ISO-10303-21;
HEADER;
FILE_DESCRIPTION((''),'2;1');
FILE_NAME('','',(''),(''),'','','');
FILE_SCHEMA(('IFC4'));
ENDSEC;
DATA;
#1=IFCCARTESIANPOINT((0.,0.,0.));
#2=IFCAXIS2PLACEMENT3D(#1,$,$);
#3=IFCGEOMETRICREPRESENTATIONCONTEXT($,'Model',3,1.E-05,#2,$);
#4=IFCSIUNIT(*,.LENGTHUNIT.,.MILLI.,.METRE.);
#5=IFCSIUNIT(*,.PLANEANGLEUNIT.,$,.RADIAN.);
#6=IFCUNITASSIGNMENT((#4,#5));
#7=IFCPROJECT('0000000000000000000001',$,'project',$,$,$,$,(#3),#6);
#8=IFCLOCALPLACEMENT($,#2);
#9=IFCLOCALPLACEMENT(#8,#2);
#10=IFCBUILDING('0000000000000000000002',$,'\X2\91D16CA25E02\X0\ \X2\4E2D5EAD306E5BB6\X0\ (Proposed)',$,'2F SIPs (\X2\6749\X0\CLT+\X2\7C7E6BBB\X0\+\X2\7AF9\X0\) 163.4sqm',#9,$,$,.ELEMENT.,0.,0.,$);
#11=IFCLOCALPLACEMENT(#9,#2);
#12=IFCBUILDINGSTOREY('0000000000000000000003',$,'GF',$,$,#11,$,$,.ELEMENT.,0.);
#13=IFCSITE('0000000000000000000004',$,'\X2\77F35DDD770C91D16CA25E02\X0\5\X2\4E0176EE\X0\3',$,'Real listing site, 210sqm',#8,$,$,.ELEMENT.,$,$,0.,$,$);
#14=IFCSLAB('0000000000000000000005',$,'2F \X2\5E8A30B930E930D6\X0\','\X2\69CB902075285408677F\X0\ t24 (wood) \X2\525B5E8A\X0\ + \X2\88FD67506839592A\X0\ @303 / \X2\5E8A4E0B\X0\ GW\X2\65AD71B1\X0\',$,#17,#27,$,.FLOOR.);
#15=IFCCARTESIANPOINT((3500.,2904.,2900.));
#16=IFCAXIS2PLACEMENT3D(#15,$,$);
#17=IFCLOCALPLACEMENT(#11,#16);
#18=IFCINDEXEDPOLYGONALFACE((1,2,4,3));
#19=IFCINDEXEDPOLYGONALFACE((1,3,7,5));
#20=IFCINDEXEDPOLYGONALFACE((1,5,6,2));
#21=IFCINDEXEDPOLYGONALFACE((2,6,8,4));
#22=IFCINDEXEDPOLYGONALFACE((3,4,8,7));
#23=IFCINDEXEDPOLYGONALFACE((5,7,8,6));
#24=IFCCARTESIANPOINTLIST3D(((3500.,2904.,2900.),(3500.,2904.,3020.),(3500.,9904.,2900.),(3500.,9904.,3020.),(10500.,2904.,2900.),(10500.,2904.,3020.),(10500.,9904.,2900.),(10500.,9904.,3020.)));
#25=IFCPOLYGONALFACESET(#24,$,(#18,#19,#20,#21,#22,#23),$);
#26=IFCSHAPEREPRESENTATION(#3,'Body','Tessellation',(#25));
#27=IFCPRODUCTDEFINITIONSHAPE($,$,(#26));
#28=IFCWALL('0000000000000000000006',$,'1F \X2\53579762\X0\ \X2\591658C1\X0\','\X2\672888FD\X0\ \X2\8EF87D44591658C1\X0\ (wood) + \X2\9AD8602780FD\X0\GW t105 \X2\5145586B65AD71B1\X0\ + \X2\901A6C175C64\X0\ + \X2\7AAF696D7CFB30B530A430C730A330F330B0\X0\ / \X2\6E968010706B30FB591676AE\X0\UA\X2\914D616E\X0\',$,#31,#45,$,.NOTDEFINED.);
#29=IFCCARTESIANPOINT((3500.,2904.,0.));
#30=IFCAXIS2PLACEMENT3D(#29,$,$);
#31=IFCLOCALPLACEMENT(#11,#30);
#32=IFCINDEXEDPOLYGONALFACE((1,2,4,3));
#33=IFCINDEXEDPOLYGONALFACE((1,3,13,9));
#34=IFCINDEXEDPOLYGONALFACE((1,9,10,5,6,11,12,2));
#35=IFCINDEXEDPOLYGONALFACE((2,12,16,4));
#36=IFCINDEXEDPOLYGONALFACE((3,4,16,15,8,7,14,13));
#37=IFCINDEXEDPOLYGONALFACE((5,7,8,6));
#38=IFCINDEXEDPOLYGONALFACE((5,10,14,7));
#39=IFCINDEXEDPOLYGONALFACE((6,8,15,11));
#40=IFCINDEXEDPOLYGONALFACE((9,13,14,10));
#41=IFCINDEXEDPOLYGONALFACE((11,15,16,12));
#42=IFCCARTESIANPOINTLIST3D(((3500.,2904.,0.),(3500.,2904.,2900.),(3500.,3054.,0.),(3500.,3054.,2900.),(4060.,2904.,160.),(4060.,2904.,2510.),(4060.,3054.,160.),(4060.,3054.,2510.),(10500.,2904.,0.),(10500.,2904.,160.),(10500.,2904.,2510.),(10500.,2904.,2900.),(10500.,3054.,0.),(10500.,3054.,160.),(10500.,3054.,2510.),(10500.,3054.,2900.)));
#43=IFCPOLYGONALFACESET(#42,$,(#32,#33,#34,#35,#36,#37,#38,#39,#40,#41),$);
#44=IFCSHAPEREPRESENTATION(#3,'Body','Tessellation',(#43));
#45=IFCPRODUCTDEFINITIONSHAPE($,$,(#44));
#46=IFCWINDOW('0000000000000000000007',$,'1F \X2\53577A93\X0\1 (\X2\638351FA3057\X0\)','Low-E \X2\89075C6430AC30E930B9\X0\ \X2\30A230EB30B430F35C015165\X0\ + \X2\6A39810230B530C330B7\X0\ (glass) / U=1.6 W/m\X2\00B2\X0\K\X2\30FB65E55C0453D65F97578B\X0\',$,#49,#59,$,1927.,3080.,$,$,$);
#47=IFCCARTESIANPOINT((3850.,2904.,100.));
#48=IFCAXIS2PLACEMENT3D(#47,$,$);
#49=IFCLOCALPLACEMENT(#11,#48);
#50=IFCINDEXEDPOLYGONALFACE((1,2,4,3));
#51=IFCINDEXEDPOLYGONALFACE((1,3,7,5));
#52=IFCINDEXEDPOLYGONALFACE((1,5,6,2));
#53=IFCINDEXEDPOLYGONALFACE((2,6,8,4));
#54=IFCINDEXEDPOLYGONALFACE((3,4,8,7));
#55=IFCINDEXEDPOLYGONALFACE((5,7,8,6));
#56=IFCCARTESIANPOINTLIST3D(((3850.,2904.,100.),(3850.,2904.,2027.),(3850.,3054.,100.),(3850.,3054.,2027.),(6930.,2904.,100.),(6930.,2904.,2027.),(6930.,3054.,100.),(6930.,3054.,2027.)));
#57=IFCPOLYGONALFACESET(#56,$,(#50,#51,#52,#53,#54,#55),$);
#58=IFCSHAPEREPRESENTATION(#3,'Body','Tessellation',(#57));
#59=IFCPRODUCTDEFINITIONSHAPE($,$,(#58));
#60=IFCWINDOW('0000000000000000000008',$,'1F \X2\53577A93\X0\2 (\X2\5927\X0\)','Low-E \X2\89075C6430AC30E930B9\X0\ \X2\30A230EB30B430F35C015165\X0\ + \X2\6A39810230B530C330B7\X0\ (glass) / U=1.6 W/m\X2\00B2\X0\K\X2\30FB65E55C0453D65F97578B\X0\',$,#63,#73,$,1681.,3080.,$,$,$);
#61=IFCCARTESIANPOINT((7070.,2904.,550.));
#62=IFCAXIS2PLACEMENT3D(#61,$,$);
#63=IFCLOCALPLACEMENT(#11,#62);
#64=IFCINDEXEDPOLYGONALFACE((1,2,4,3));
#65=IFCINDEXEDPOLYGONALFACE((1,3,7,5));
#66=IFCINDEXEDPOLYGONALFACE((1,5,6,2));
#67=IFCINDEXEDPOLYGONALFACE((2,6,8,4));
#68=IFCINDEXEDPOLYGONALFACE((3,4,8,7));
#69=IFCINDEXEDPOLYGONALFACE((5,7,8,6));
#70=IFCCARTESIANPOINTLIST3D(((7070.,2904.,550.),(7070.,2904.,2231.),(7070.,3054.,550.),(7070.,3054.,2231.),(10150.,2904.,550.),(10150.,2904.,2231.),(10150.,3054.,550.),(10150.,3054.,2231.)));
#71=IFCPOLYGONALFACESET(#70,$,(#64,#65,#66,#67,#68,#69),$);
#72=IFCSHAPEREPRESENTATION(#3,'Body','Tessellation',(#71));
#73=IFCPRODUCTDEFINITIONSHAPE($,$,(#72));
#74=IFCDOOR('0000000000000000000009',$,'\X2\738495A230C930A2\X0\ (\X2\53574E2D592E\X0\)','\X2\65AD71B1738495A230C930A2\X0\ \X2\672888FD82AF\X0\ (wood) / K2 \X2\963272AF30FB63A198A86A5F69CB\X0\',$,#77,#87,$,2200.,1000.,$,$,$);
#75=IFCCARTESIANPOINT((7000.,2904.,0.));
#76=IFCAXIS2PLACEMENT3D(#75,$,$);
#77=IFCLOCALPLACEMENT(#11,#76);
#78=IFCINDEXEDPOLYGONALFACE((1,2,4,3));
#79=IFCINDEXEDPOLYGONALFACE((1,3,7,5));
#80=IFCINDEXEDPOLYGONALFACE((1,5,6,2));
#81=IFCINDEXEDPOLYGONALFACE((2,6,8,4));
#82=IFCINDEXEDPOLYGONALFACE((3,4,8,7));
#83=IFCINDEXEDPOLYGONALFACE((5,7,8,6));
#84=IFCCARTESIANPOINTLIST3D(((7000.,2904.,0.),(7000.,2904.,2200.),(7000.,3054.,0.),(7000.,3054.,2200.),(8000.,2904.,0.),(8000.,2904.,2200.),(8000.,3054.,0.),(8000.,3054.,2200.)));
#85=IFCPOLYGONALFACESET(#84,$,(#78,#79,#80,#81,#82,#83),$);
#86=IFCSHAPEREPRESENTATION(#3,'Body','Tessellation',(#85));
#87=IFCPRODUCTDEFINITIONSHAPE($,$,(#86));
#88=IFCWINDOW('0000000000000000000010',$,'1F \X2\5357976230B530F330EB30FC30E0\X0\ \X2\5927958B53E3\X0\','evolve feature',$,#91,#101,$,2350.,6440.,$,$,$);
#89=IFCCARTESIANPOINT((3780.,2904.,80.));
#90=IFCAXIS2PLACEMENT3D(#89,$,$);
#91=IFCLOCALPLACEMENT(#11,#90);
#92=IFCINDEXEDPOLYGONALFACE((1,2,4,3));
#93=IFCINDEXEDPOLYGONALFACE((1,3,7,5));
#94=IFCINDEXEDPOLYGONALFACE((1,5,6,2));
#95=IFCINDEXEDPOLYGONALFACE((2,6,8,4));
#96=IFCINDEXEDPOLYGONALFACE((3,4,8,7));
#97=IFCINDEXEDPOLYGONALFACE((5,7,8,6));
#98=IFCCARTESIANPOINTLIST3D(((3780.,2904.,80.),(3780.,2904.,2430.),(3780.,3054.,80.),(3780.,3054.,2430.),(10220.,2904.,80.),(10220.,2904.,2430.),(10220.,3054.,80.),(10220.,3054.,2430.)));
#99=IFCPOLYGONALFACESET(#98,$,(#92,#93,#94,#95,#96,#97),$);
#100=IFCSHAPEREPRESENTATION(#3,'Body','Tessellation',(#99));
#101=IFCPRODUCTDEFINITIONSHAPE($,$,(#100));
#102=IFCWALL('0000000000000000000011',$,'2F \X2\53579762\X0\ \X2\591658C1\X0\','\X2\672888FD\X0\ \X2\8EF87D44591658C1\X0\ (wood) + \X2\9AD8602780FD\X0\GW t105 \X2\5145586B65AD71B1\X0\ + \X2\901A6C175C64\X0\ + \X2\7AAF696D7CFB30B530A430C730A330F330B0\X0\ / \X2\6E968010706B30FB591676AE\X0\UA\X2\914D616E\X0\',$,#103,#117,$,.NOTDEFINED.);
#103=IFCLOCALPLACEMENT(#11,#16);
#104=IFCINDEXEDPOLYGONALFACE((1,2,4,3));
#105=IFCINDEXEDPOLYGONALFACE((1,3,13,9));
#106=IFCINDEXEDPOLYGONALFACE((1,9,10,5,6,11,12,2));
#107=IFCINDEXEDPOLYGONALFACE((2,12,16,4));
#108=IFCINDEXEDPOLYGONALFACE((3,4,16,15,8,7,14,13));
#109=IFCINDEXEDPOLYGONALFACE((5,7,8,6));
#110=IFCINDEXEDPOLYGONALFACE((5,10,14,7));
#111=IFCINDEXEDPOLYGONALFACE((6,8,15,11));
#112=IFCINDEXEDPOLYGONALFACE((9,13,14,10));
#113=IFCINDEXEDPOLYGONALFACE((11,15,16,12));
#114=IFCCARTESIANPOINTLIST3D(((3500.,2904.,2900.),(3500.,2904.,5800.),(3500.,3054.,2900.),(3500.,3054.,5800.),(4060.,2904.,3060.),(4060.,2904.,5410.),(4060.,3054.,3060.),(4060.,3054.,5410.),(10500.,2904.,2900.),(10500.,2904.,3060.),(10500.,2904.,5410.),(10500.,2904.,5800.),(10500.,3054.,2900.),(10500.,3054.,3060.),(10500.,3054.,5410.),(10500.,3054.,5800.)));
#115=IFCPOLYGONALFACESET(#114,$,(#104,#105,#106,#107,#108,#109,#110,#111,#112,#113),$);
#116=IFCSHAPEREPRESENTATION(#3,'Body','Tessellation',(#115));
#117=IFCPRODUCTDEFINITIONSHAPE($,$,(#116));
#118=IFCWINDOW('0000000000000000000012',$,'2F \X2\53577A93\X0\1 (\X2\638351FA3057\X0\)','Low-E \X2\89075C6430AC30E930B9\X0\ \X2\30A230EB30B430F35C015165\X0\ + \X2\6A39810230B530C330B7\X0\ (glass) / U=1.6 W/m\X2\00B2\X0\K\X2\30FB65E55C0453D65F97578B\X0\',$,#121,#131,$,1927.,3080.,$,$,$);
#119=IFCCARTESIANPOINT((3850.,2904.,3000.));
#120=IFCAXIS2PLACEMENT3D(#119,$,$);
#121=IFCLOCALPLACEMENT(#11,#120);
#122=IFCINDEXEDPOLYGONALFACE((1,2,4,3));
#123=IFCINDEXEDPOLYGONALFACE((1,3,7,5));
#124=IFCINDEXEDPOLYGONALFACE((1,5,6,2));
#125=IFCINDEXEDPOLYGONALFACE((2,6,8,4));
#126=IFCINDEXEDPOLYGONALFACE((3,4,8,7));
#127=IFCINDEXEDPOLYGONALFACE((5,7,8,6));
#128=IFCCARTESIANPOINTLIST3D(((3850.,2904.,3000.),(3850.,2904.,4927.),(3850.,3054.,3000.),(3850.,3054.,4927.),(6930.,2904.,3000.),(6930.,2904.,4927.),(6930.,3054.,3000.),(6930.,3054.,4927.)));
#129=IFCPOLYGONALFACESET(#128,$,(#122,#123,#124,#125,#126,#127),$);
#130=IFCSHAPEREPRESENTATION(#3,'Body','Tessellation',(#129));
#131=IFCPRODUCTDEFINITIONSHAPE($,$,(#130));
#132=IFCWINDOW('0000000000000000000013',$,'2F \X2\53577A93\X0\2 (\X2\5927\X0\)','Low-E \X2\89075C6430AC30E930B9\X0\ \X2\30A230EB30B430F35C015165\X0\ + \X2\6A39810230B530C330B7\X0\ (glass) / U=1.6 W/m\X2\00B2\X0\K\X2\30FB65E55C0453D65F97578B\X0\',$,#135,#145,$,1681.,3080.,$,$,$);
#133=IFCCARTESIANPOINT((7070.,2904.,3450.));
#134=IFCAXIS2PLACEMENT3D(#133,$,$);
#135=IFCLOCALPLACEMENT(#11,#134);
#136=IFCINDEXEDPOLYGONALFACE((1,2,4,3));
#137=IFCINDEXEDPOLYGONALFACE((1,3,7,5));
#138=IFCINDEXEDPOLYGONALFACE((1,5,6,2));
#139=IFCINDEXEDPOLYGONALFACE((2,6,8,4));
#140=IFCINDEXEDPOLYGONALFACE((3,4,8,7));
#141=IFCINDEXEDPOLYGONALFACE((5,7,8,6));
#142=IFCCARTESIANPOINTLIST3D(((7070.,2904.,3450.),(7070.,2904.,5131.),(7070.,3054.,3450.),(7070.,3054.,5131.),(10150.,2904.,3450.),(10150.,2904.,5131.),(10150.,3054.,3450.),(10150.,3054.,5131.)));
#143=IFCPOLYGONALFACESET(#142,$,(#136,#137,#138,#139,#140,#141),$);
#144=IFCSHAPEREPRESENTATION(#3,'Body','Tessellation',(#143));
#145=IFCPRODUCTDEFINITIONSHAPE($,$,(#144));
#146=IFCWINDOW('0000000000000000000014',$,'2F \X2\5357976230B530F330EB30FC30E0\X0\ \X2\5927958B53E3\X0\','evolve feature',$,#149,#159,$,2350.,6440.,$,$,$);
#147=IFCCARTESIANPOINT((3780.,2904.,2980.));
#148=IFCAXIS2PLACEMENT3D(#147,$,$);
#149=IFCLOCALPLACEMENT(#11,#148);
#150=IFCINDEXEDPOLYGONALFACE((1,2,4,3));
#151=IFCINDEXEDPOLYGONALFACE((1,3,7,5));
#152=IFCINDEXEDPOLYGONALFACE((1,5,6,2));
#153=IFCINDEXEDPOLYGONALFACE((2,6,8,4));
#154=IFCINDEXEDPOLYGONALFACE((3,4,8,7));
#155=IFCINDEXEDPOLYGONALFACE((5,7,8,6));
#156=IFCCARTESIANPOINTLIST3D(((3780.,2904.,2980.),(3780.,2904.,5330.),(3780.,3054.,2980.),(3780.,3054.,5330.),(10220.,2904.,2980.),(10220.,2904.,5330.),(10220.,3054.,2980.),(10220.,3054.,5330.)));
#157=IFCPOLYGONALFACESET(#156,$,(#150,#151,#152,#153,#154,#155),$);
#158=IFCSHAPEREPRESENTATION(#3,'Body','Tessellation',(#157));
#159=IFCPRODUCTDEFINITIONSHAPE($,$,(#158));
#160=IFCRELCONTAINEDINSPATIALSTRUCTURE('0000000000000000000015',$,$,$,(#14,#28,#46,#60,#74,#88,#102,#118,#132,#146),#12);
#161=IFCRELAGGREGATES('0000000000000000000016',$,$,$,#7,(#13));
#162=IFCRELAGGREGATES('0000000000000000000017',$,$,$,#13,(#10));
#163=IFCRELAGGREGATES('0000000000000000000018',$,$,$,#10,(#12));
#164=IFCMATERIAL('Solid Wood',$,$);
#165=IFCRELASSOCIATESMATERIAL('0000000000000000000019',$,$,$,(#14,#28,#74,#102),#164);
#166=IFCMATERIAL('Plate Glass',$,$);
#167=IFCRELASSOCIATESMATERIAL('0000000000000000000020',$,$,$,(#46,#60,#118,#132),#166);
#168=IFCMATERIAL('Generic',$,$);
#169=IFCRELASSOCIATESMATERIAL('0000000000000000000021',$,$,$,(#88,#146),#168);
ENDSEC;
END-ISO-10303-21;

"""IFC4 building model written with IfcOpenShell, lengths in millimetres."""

from ifc_helpers import new_model, si_unit, frame, frame_2d, origin, place, context, project, spatial, rectangle, extrude, material, element, fill, save


model = new_model("IFC4")

# Units and contexts
model_context = context("Model", 3, precision=1e-05, world=origin())
ifc_project = project(units=[si_unit("LENGTHUNIT", "METRE", prefix="MILLI"), si_unit("PLANEANGLEUNIT", "RADIAN")], contexts=[model_context])

# Site, building, storey
site_placement = place(None, origin())
site = spatial("IfcSite", under=ifc_project, at=site_placement, Name="石川県金沢市5丁目3", ObjectType="Real listing site, 210sqm", CompositionType="ELEMENT", RefElevation=0.0)
building_placement = place(site_placement, origin())
building = spatial("IfcBuilding", under=site, at=building_placement, Name="金沢市 中庭の家 (Proposed)", ObjectType="2F SIPs (杉CLT+籾殻+竹) 163.4sqm", CompositionType="ELEMENT", ElevationOfRefHeight=0.0, ElevationOfTerrain=0.0)
storey_placement = place(building_placement, origin())
storey = spatial("IfcBuildingStorey", under=building, at=storey_placement, Name="GF", CompositionType="ELEMENT", Elevation=0.0)

# Slab
ifc_material_1 = material(Name="Solid Wood")
slab_1_placement = place(storey_placement, frame((3500.0, 2904.0, 2900.0)))
element("IfcSlab", 1, at=slab_1_placement, inside=storey, material=ifc_material_1, Name="2F 床スラブ", Description="構造用合板 t24 (wood) 剛床 + 製材根太 @303 / 床下 GW断熱", PredefinedType="FLOOR", context=model_context, shape_type="SweptSolid", body=[
    extrude(rectangle(XDim=7000.0, YDim=7000.0, at=frame_2d((3500.0, 3500.0))), frame((3500.0, 2904.0, 2900.0)), (0.0, 0.0, 1.0), 120.0),
])
ifc_material_2 = material(Name="Generic")

# Wall, openings, windows, door
wall_1_placement = place(storey_placement, frame((3500.0, 2904.0, 0.0)))
wall_1 = element("IfcWall", 2, at=wall_1_placement, inside=storey, material=ifc_material_1, Name="1F 南面 外壁", Description="木製 軸組外壁 (wood) + 高性能GW t105 充填断熱 + 通気層 + 窯業系サイディング / 準耐火・外皮UA配慮", PredefinedType="NOTDEFINED", context=model_context, shape_type="SweptSolid", body=[
    extrude(rectangle(XDim=7000.0, YDim=150.0, at=frame_2d((3500.0, 75.0))), frame((3500.0, 2904.0, 0.0)), (0.0, 0.0, 1.0), 2900.0),
])
opening_1_placement = place(storey_placement, frame((3850.0, 2904.0, 100.0)))
opening_1 = element("IfcOpeningElement", 3, at=opening_1_placement, cuts=wall_1, PredefinedType="NOTDEFINED", context=model_context, shape_type="SweptSolid", body=[
    extrude(rectangle(XDim=3080.0, YDim=150.0, at=frame_2d((1540.0, 75.0))), frame((3850.0, 2904.0, 100.0)), (0.0, 0.0, 1.0), 1927.0),
])
opening_2_placement = place(storey_placement, frame((7070.0, 2904.0, 550.0)))
opening_2 = element("IfcOpeningElement", 4, at=opening_2_placement, cuts=wall_1, PredefinedType="NOTDEFINED", context=model_context, shape_type="SweptSolid", body=[
    extrude(rectangle(XDim=3080.0, YDim=150.0, at=frame_2d((1540.0, 75.0))), frame((7070.0, 2904.0, 550.0)), (0.0, 0.0, 1.0), 1681.0),
])
opening_3_placement = place(storey_placement, frame((7000.0, 2904.0, 0.0)))
opening_3 = element("IfcOpeningElement", 5, at=opening_3_placement, cuts=wall_1, PredefinedType="NOTDEFINED", context=model_context, shape_type="SweptSolid", body=[
    extrude(rectangle(XDim=1000.0, YDim=150.0, at=frame_2d((500.0, 75.0))), frame((7000.0, 2904.0, 0.0)), (0.0, 0.0, 1.0), 2200.0),
])
opening_4_placement = place(storey_placement, frame((3780.0, 2904.0, 80.0)))
opening_4 = element("IfcOpeningElement", 6, at=opening_4_placement, cuts=wall_1, PredefinedType="NOTDEFINED", context=model_context, shape_type="SweptSolid", body=[
    extrude(rectangle(XDim=6440.0, YDim=150.0, at=frame_2d((3220.0, 75.0))), frame((3780.0, 2904.0, 80.0)), (0.0, 0.0, 1.0), 2350.0),
])
ifc_material_3 = material(Name="Plate Glass")
window_1_placement = place(storey_placement, frame((3850.0, 2904.0, 100.0)))
window_1 = element("IfcWindow", 7, at=window_1_placement, inside=storey, material=ifc_material_3, Name="1F 南窓1 (掃出し)", Description="Low-E 複層ガラス アルゴン封入 + 樹脂サッシ (glass) / U=1.6 W/m²K・日射取得型", OverallHeight=1927.0, OverallWidth=3080.0, context=model_context, shape_type="SweptSolid", body=[
    extrude(rectangle(XDim=3080.0, YDim=150.0, at=frame_2d((1540.0, 75.0))), frame((3850.0, 2904.0, 100.0)), (0.0, 0.0, 1.0), 1927.0),
])
fill(opening_1, window_1)
window_2_placement = place(storey_placement, frame((7070.0, 2904.0, 550.0)))
window_2 = element("IfcWindow", 8, at=window_2_placement, inside=storey, material=ifc_material_3, Name="1F 南窓2 (大)", Description="Low-E 複層ガラス アルゴン封入 + 樹脂サッシ (glass) / U=1.6 W/m²K・日射取得型", OverallHeight=1681.0, OverallWidth=3080.0, context=model_context, shape_type="SweptSolid", body=[
    extrude(rectangle(XDim=3080.0, YDim=150.0, at=frame_2d((1540.0, 75.0))), frame((7070.0, 2904.0, 550.0)), (0.0, 0.0, 1.0), 1681.0),
])
fill(opening_2, window_2)
door_placement = place(storey_placement, frame((7000.0, 2904.0, 0.0)))
door = element("IfcDoor", 9, at=door_placement, inside=storey, material=ifc_material_1, Name="玄関ドア (南中央)", Description="断熱玄関ドア 木製芯 (wood) / K2 防犯・採風機構", OverallHeight=2200.0, OverallWidth=1000.0, context=model_context, shape_type="SweptSolid", body=[
    extrude(rectangle(XDim=1000.0, YDim=150.0, at=frame_2d((500.0, 75.0))), frame((7000.0, 2904.0, 0.0)), (0.0, 0.0, 1.0), 2200.0),
])
fill(opening_3, door)
window_3_placement = place(storey_placement, frame((3780.0, 2904.0, 80.0)))
window_3 = element("IfcWindow", 10, at=window_3_placement, inside=storey, material=ifc_material_2, Name="1F 南面サンルーム 大開口", Description="evolve feature", OverallHeight=2350.0, OverallWidth=6440.0, context=model_context, shape_type="SweptSolid", body=[
    extrude(rectangle(XDim=6440.0, YDim=150.0, at=frame_2d((3220.0, 75.0))), frame((3780.0, 2904.0, 80.0)), (0.0, 0.0, 1.0), 2350.0),
])
fill(opening_4, window_3)

# Wall, openings, windows
wall_2_placement = place(storey_placement, frame((3500.0, 2904.0, 2900.0)))
wall_2 = element("IfcWall", 11, at=wall_2_placement, inside=storey, material=ifc_material_1, Name="2F 南面 外壁", Description="木製 軸組外壁 (wood) + 高性能GW t105 充填断熱 + 通気層 + 窯業系サイディング / 準耐火・外皮UA配慮", PredefinedType="NOTDEFINED", context=model_context, shape_type="SweptSolid", body=[
    extrude(rectangle(XDim=7000.0, YDim=150.0, at=frame_2d((3500.0, 75.0))), frame((3500.0, 2904.0, 2900.0)), (0.0, 0.0, 1.0), 2900.0),
])
opening_5_placement = place(storey_placement, frame((3850.0, 2904.0, 3000.0)))
opening_5 = element("IfcOpeningElement", 12, at=opening_5_placement, cuts=wall_2, PredefinedType="NOTDEFINED", context=model_context, shape_type="SweptSolid", body=[
    extrude(rectangle(XDim=3080.0, YDim=150.0, at=frame_2d((1540.0, 75.0))), frame((3850.0, 2904.0, 3000.0)), (0.0, 0.0, 1.0), 1927.0),
])
opening_6_placement = place(storey_placement, frame((7070.0, 2904.0, 3450.0)))
opening_6 = element("IfcOpeningElement", 13, at=opening_6_placement, cuts=wall_2, PredefinedType="NOTDEFINED", context=model_context, shape_type="SweptSolid", body=[
    extrude(rectangle(XDim=3080.0, YDim=150.0, at=frame_2d((1540.0, 75.0))), frame((7070.0, 2904.0, 3450.0)), (0.0, 0.0, 1.0), 1681.0),
])
opening_7_placement = place(storey_placement, frame((3780.0, 2904.0, 2980.0)))
opening_7 = element("IfcOpeningElement", 14, at=opening_7_placement, cuts=wall_2, PredefinedType="NOTDEFINED", context=model_context, shape_type="SweptSolid", body=[
    extrude(rectangle(XDim=6440.0, YDim=150.0, at=frame_2d((3220.0, 75.0))), frame((3780.0, 2904.0, 2980.0)), (0.0, 0.0, 1.0), 2350.0),
])
window_4_placement = place(storey_placement, frame((3850.0, 2904.0, 3000.0)))
window_4 = element("IfcWindow", 15, at=window_4_placement, inside=storey, material=ifc_material_3, Name="2F 南窓1 (掃出し)", Description="Low-E 複層ガラス アルゴン封入 + 樹脂サッシ (glass) / U=1.6 W/m²K・日射取得型", OverallHeight=1927.0, OverallWidth=3080.0, context=model_context, shape_type="SweptSolid", body=[
    extrude(rectangle(XDim=3080.0, YDim=150.0, at=frame_2d((1540.0, 75.0))), frame((3850.0, 2904.0, 3000.0)), (0.0, 0.0, 1.0), 1927.0),
])
fill(opening_5, window_4)
window_5_placement = place(storey_placement, frame((7070.0, 2904.0, 3450.0)))
window_5 = element("IfcWindow", 16, at=window_5_placement, inside=storey, material=ifc_material_3, Name="2F 南窓2 (大)", Description="Low-E 複層ガラス アルゴン封入 + 樹脂サッシ (glass) / U=1.6 W/m²K・日射取得型", OverallHeight=1681.0, OverallWidth=3080.0, context=model_context, shape_type="SweptSolid", body=[
    extrude(rectangle(XDim=3080.0, YDim=150.0, at=frame_2d((1540.0, 75.0))), frame((7070.0, 2904.0, 3450.0)), (0.0, 0.0, 1.0), 1681.0),
])
fill(opening_6, window_5)
window_6_placement = place(storey_placement, frame((3780.0, 2904.0, 2980.0)))
window_6 = element("IfcWindow", 17, at=window_6_placement, inside=storey, material=ifc_material_2, Name="2F 南面サンルーム 大開口", Description="evolve feature", OverallHeight=2350.0, OverallWidth=6440.0, context=model_context, shape_type="SweptSolid", body=[
    extrude(rectangle(XDim=6440.0, YDim=150.0, at=frame_2d((3220.0, 75.0))), frame((3780.0, 2904.0, 2980.0)), (0.0, 0.0, 1.0), 2350.0),
])
fill(opening_7, window_6)

save(model, "model.ifc")
